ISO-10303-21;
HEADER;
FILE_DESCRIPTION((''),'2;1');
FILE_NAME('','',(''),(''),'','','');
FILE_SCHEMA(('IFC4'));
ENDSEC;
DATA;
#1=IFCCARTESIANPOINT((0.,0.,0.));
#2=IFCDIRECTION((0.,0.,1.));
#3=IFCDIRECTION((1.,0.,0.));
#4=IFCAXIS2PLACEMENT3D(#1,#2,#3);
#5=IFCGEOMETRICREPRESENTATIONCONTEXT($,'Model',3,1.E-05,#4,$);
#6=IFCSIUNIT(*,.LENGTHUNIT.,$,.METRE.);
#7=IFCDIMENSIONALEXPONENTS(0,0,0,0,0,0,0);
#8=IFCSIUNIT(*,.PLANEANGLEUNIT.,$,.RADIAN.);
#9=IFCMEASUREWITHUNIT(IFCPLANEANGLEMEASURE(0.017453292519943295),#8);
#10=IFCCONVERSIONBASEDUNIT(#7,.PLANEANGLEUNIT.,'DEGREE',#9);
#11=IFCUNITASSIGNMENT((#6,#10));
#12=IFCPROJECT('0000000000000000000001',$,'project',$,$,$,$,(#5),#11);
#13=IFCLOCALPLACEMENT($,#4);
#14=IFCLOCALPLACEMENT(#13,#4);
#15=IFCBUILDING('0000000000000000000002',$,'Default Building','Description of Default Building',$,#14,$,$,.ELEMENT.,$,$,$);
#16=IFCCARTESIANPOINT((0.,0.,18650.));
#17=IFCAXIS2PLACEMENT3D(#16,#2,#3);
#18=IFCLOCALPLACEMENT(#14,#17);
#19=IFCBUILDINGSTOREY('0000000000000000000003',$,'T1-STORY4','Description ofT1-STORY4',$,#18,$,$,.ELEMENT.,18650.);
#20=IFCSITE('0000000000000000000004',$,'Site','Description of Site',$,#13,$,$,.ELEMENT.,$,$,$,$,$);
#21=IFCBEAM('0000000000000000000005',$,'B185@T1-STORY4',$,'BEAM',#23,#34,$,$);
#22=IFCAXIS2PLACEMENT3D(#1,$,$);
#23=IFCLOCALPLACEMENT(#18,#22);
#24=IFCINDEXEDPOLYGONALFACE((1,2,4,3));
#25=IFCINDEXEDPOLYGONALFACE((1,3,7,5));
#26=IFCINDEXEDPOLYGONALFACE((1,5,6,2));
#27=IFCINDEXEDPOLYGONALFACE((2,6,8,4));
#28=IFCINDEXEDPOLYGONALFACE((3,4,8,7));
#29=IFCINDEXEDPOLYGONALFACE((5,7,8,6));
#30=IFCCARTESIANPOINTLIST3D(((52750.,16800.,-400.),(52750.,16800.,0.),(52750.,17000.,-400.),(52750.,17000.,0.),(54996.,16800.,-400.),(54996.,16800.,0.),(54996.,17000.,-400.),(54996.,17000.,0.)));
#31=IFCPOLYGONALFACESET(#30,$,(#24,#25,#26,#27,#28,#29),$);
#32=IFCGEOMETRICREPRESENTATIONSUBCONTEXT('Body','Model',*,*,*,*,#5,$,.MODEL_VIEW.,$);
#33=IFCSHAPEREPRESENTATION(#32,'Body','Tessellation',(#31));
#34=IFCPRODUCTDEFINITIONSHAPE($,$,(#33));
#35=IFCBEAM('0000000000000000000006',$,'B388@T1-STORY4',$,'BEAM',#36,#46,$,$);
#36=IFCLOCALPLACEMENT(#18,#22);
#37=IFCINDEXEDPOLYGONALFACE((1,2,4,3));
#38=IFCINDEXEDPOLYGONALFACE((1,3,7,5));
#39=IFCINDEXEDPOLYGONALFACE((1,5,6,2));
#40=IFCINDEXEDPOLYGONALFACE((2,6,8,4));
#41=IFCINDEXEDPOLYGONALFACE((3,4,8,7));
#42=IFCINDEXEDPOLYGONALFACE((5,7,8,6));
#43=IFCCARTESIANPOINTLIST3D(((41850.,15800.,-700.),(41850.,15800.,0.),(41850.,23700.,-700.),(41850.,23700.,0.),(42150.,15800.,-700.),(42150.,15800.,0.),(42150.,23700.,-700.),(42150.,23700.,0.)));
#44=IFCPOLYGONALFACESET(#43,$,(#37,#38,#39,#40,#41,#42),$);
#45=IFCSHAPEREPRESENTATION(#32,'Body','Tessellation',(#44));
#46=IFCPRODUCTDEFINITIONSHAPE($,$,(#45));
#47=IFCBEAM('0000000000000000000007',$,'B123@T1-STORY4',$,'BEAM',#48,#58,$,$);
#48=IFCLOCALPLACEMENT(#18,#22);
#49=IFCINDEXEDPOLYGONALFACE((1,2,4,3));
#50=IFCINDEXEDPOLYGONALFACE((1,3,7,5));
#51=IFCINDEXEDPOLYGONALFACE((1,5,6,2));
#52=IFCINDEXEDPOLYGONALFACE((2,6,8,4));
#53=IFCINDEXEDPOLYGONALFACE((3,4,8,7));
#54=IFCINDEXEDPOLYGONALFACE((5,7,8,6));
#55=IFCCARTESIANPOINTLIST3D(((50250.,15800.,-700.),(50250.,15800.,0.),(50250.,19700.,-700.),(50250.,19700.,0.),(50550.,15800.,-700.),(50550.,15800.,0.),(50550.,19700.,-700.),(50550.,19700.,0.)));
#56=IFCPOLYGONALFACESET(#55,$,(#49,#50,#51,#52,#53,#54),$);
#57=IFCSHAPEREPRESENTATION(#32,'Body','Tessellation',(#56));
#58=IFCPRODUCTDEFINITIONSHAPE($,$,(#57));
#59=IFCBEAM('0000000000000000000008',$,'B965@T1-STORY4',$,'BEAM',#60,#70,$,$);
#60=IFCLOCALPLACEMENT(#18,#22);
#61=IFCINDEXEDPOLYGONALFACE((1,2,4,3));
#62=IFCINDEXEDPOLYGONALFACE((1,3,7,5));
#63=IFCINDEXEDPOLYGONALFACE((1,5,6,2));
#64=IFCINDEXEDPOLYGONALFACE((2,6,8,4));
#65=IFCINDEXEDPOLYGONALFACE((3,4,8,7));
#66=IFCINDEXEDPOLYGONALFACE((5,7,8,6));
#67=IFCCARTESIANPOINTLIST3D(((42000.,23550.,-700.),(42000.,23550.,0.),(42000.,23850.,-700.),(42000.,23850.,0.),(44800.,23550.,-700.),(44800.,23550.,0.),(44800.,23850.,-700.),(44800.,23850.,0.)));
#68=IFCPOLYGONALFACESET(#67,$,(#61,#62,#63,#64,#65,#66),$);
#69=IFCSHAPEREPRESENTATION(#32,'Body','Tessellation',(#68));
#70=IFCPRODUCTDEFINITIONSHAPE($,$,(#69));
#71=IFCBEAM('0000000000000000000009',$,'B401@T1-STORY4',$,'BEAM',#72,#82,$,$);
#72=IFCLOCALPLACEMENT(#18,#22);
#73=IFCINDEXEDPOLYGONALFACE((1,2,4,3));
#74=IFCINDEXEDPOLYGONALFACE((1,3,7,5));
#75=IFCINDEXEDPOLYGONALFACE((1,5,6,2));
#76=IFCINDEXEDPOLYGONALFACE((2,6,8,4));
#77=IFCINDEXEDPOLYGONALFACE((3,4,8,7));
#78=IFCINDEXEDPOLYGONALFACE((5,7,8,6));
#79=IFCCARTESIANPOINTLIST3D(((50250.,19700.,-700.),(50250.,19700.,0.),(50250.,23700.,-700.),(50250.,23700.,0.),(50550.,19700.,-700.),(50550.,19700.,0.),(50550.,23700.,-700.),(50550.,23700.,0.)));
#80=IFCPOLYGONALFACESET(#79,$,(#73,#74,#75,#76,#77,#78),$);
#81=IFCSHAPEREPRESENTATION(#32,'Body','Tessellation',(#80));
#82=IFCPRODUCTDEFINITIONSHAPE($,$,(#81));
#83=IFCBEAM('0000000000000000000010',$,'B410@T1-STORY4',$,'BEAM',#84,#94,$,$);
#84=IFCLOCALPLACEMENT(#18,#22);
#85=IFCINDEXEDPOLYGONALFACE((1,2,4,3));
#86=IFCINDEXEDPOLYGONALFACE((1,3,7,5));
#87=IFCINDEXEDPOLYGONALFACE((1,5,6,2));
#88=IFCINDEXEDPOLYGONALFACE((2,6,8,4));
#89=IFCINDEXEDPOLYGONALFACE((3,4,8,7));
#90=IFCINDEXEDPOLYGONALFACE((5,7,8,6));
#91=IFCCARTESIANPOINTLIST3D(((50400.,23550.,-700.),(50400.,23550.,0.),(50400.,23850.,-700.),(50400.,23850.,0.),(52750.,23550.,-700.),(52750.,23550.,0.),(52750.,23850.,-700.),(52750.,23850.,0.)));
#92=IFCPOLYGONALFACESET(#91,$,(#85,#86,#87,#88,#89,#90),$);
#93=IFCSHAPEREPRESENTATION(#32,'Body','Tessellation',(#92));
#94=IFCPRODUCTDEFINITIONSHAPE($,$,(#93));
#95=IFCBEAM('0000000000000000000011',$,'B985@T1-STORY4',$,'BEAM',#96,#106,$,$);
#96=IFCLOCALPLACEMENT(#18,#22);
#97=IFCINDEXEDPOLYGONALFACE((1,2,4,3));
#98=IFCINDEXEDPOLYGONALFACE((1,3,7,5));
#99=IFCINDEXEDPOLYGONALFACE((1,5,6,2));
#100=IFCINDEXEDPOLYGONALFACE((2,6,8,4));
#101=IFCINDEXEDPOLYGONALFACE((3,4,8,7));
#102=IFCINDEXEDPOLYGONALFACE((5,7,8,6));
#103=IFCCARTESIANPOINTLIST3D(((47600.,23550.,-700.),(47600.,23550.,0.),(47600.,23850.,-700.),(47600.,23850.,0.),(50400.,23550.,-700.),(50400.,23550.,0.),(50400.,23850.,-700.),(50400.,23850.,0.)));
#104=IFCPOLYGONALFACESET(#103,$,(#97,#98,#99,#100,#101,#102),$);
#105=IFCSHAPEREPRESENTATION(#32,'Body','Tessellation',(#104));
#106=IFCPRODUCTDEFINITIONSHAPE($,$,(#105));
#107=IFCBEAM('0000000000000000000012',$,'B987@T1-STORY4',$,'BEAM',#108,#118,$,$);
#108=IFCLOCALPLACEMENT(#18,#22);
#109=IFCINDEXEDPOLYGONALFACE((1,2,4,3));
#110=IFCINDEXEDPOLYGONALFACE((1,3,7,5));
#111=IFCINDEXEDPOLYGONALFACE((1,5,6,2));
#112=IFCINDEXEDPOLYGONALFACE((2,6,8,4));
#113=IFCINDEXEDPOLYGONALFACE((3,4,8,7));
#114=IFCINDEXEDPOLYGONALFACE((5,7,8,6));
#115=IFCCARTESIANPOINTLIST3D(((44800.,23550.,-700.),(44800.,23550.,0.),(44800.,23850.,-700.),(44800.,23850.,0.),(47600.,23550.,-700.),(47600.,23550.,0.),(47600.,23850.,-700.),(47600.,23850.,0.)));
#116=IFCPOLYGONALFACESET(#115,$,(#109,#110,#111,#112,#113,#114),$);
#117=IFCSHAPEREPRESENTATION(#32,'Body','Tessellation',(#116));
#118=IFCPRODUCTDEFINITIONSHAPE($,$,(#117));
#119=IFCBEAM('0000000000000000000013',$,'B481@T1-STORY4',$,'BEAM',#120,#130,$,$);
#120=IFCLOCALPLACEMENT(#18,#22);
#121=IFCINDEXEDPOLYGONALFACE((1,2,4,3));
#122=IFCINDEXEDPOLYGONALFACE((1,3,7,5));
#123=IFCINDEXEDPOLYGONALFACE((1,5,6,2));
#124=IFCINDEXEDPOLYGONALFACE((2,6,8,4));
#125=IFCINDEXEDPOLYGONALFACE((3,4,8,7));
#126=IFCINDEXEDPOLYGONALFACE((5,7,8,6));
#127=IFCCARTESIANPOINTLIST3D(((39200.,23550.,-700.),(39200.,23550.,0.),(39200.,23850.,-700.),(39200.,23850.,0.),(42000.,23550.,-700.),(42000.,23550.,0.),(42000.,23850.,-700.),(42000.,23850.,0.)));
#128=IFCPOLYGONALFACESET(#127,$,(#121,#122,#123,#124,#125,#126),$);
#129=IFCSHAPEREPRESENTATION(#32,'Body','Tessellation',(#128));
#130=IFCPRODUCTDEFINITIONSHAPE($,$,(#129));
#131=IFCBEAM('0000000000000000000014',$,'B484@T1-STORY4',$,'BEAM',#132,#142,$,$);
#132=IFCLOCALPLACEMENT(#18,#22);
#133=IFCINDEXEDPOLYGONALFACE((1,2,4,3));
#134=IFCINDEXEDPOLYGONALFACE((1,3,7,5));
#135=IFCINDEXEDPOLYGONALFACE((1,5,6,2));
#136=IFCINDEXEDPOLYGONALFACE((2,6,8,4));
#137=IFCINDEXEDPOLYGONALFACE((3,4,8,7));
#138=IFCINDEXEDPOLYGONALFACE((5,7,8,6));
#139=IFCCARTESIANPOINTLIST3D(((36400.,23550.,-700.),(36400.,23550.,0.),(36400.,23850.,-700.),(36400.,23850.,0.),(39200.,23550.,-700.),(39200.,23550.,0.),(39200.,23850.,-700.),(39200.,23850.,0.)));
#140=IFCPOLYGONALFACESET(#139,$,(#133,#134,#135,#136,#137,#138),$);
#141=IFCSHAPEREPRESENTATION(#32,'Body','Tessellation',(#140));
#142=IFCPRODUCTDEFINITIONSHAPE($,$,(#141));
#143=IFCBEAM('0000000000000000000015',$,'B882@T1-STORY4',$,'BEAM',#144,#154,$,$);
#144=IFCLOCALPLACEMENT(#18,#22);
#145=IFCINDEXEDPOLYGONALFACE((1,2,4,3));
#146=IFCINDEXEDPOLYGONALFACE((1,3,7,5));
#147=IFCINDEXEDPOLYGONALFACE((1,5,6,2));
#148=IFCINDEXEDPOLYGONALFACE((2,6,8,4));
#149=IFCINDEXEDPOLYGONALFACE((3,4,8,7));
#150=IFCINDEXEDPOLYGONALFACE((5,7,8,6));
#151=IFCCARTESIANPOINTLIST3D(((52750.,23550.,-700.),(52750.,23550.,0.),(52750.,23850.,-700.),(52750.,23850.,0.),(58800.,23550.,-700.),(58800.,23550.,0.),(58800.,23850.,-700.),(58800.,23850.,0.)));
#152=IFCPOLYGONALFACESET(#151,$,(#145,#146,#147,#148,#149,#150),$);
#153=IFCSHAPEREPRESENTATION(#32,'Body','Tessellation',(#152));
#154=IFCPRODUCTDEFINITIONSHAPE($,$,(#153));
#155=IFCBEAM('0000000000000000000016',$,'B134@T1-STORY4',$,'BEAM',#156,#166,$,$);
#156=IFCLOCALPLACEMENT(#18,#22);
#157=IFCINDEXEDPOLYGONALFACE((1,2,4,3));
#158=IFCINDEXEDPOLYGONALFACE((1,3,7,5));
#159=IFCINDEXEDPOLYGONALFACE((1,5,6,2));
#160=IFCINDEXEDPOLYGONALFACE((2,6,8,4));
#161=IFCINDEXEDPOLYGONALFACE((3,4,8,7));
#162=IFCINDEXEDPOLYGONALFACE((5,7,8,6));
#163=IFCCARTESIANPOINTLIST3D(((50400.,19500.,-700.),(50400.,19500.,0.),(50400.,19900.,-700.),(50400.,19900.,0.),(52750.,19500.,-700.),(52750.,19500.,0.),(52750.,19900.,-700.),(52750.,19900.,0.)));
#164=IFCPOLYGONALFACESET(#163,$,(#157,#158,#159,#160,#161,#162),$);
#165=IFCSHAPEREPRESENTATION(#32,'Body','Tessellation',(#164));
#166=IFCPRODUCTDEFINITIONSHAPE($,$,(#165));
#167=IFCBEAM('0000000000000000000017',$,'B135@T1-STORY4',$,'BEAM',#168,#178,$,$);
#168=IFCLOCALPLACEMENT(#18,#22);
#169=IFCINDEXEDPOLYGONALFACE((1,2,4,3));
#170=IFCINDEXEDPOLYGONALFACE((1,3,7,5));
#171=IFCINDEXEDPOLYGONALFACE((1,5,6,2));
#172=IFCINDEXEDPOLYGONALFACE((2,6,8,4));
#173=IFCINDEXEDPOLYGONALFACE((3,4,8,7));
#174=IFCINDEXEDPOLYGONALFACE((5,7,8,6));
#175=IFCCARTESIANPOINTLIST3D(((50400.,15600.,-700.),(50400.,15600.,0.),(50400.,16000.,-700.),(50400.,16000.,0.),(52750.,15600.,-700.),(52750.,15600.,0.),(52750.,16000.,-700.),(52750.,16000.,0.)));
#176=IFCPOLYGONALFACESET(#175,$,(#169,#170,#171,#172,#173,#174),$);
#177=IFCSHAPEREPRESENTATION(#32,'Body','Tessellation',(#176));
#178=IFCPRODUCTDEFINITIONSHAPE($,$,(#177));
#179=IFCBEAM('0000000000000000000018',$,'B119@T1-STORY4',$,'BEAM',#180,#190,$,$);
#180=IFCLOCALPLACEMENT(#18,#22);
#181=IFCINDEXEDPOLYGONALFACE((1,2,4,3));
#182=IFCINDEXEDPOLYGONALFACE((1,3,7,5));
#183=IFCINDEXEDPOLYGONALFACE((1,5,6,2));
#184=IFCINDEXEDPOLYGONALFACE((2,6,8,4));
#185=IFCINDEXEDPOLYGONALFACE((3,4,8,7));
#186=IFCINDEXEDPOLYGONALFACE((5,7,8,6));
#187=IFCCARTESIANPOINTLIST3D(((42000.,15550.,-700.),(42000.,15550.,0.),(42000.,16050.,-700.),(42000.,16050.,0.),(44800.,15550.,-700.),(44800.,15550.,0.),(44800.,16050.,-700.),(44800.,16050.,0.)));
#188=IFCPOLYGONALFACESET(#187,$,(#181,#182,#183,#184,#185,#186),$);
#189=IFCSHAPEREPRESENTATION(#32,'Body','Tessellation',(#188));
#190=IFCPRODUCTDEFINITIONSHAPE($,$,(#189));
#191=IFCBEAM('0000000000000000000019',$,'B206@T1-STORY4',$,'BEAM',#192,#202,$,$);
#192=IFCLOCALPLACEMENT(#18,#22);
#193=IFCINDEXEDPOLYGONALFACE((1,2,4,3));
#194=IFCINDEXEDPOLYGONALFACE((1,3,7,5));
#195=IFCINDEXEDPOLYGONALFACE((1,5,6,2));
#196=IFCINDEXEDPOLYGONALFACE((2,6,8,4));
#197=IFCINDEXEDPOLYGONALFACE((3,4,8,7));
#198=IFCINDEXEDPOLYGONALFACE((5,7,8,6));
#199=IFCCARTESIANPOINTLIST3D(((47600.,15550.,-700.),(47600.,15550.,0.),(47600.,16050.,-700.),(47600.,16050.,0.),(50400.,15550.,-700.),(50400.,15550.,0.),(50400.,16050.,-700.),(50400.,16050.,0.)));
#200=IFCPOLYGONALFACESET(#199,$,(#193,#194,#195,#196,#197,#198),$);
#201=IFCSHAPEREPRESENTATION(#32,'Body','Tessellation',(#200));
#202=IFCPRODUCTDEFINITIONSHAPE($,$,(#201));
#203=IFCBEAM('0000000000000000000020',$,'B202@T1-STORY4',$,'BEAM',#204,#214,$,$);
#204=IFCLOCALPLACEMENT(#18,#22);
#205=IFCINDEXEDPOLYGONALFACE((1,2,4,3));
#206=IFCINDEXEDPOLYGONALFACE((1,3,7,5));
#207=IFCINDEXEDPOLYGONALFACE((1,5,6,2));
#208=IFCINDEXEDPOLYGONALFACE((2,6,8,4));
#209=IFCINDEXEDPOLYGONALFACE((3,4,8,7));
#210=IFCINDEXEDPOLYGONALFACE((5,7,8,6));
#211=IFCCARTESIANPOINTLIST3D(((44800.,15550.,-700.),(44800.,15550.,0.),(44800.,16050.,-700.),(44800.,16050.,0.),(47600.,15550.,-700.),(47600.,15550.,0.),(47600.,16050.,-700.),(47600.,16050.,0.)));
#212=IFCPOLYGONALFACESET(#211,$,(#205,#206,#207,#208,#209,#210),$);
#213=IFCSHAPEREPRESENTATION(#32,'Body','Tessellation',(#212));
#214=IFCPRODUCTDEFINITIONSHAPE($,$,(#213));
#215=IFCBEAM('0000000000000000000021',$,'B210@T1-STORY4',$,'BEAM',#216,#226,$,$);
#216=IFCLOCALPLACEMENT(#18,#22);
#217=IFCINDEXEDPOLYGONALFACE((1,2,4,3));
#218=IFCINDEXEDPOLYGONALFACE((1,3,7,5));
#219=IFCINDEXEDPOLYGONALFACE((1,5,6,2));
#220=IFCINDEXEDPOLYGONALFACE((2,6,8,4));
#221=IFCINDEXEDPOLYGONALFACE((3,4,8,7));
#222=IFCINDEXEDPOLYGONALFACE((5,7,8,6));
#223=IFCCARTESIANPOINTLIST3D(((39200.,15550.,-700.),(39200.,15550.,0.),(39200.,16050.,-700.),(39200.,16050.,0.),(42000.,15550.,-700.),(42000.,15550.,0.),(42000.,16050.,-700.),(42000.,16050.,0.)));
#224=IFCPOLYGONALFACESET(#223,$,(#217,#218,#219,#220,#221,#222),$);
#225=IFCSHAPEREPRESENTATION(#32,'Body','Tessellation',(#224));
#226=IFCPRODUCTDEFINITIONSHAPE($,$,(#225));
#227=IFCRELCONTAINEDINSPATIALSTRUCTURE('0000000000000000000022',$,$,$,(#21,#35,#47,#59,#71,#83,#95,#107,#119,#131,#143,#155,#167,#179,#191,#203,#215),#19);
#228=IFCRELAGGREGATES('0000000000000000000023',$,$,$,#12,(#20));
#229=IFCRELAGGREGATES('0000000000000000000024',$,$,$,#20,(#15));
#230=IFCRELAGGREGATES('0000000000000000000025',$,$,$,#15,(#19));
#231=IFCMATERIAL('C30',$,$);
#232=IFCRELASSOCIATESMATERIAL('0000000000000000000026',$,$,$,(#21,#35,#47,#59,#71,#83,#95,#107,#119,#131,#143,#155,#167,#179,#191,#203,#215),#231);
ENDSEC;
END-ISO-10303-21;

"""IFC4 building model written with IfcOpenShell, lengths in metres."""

from ifc_helpers import new_model, entity, si_unit, converted_unit, frame, origin_with_axes, place, context, subcontext, project, spatial, rectangle, extrude, material, element, save


model = new_model("IFC4")

# Units and contexts
model_context = context("Model", 3, precision=1e-05, world=origin_with_axes())
body_context = subcontext(model_context, "Body", "Model", "MODEL_VIEW")
ifc_project = project(units=[si_unit("LENGTHUNIT", "METRE"), converted_unit("PLANEANGLEUNIT", "DEGREE", entity("IfcPlaneAngleMeasure", 0.017453292519943295), si_unit("PLANEANGLEUNIT", "RADIAN"), dimensions=[0, 0, 0, 0, 0, 0, 0])], contexts=[model_context])

# Site, building, storey
site_placement = place(None, origin_with_axes())
site = spatial("IfcSite", under=ifc_project, at=site_placement, Name="Site", Description="Description of Site", CompositionType="ELEMENT")
building_placement = place(site_placement, origin_with_axes())
building = spatial("IfcBuilding", under=site, at=building_placement, Name="Default Building", Description="Description of Default Building", CompositionType="ELEMENT")
storey_placement = place(building_placement, frame((0.0, 0.0, 18650.0), z_axis=(0.0, 0.0, 1.0), x_axis=(1.0, 0.0, 0.0)))
storey = spatial("IfcBuildingStorey", under=building, at=storey_placement, Name="T1-STORY4", Description="Description ofT1-STORY4", CompositionType="ELEMENT", Elevation=18650.0)

# Beams
ifc_material_1 = material(Name="C30")
beam_1_placement = place(storey_placement, frame((52750.0, 16900.0, -200.0), z_axis=(1.0, 0.0, 0.0), x_axis=(0.0, 1.0, 0.0)))
element("IfcBeam", 1, at=beam_1_placement, inside=storey, material=ifc_material_1, Name="B185@T1-STORY4", ObjectType="BEAM", context=body_context, shape_type="SweptSolid", body=[
    extrude(rectangle(XDim=200.0, YDim=400.0), origin_with_axes(), (0.0, 0.0, 1.0), 2246.0),
])
beam_2_placement = place(storey_placement, frame((42000.0, 15800.0, -350.0), z_axis=(0.0, 1.0, 0.0), x_axis=(-1.0, 0.0, 0.0)))
element("IfcBeam", 2, at=beam_2_placement, inside=storey, material=ifc_material_1, Name="B388@T1-STORY4", ObjectType="BEAM", context=body_context, shape_type="SweptSolid", body=[
    extrude(rectangle(XDim=300.0, YDim=700.0), origin_with_axes(), (0.0, 0.0, 1.0), 7900.0),
])
beam_3_placement = place(storey_placement, frame((50400.0, 15800.0, -350.0), z_axis=(0.0, 1.0, 0.0), x_axis=(-1.0, 0.0, 0.0)))
element("IfcBeam", 3, at=beam_3_placement, inside=storey, material=ifc_material_1, Name="B123@T1-STORY4", ObjectType="BEAM", context=body_context, shape_type="SweptSolid", body=[
    extrude(rectangle(XDim=300.0, YDim=700.0), origin_with_axes(), (0.0, 0.0, 1.0), 3900.0),
])
beam_4_placement = place(storey_placement, frame((42000.0, 23700.0, -350.0), z_axis=(1.0, 0.0, 0.0), x_axis=(0.0, 1.0, 0.0)))
element("IfcBeam", 4, at=beam_4_placement, inside=storey, material=ifc_material_1, Name="B965@T1-STORY4", ObjectType="BEAM", context=body_context, shape_type="SweptSolid", body=[
    extrude(rectangle(XDim=300.0, YDim=700.0), origin_with_axes(), (0.0, 0.0, 1.0), 2800.0),
])
beam_5_placement = place(storey_placement, frame((50400.0, 19700.0, -350.0), z_axis=(0.0, 1.0, 0.0), x_axis=(-1.0, 0.0, 0.0)))
element("IfcBeam", 5, at=beam_5_placement, inside=storey, material=ifc_material_1, Name="B401@T1-STORY4", ObjectType="BEAM", context=body_context, shape_type="SweptSolid", body=[
    extrude(rectangle(XDim=300.0, YDim=700.0), origin_with_axes(), (0.0, 0.0, 1.0), 4000.0),
])
beam_6_placement = place(storey_placement, frame((50400.0, 23700.0, -350.0), z_axis=(1.0, 0.0, 0.0), x_axis=(0.0, 1.0, 0.0)))
element("IfcBeam", 6, at=beam_6_placement, inside=storey, material=ifc_material_1, Name="B410@T1-STORY4", ObjectType="BEAM", context=body_context, shape_type="SweptSolid", body=[
    extrude(rectangle(XDim=300.0, YDim=700.0), origin_with_axes(), (0.0, 0.0, 1.0), 2350.0),
])
for number, where, z_axis, x_axis, name in (
    (7, (47600.0, 23700.0, -350.0), (1.0, 0.0, 0.0), (0.0, 1.0, 0.0), "B985@T1-STORY4"),
    (8, (44800.0, 23700.0, -350.0), (1.0, 0.0, 0.0), (0.0, 1.0, 0.0), "B987@T1-STORY4"),
    (9, (39200.0, 23700.0, -350.0), (1.0, 0.0, 0.0), (0.0, 1.0, 0.0), "B481@T1-STORY4"),
    (10, (36400.0, 23700.0, -350.0), (1.0, 0.0, 0.0), (0.0, 1.0, 0.0), "B484@T1-STORY4"),
):
    element("IfcBeam", number, at=place(storey_placement, frame(where, z_axis=z_axis, x_axis=x_axis)), inside=storey, material=ifc_material_1, Name=name, ObjectType="BEAM", context=body_context, shape_type="SweptSolid", body=[
        extrude(rectangle(XDim=300.0, YDim=700.0), origin_with_axes(), (0.0, 0.0, 1.0), 2800.0),
    ])
beam_7_placement = place(storey_placement, frame((52750.0, 23700.0, -350.0), z_axis=(1.0, 0.0, 0.0), x_axis=(0.0, 1.0, 0.0)))
element("IfcBeam", 11, at=beam_7_placement, inside=storey, material=ifc_material_1, Name="B882@T1-STORY4", ObjectType="BEAM", context=body_context, shape_type="SweptSolid", body=[
    extrude(rectangle(XDim=300.0, YDim=700.0), origin_with_axes(), (0.0, 0.0, 1.0), 6050.0),
])
for number, where, z_axis, x_axis, name in (
    (12, (50400.0, 19700.0, -350.0), (1.0, 0.0, 0.0), (0.0, 1.0, 0.0), "B134@T1-STORY4"),
    (13, (50400.0, 15800.0, -350.0), (1.0, 0.0, 0.0), (0.0, 1.0, 0.0), "B135@T1-STORY4"),
):
    element("IfcBeam", number, at=place(storey_placement, frame(where, z_axis=z_axis, x_axis=x_axis)), inside=storey, material=ifc_material_1, Name=name, ObjectType="BEAM", context=body_context, shape_type="SweptSolid", body=[
        extrude(rectangle(XDim=400.0, YDim=700.0), origin_with_axes(), (0.0, 0.0, 1.0), 2350.0),
    ])
for number, where, z_axis, x_axis, name in (
    (14, (42000.0, 15800.0, -350.0), (1.0, 0.0, 0.0), (0.0, 1.0, 0.0), "B119@T1-STORY4"),
    (15, (47600.0, 15800.0, -350.0), (1.0, 0.0, 0.0), (0.0, 1.0, 0.0), "B206@T1-STORY4"),
    (16, (44800.0, 15800.0, -350.0), (1.0, 0.0, 0.0), (0.0, 1.0, 0.0), "B202@T1-STORY4"),
    (17, (39200.0, 15800.0, -350.0), (1.0, 0.0, 0.0), (0.0, 1.0, 0.0), "B210@T1-STORY4"),
):
    element("IfcBeam", number, at=place(storey_placement, frame(where, z_axis=z_axis, x_axis=x_axis)), inside=storey, material=ifc_material_1, Name=name, ObjectType="BEAM", context=body_context, shape_type="SweptSolid", body=[
        extrude(rectangle(XDim=500.0, YDim=700.0), origin_with_axes(), (0.0, 0.0, 1.0), 2800.0),
    ])

save(model, "model.ifc")
